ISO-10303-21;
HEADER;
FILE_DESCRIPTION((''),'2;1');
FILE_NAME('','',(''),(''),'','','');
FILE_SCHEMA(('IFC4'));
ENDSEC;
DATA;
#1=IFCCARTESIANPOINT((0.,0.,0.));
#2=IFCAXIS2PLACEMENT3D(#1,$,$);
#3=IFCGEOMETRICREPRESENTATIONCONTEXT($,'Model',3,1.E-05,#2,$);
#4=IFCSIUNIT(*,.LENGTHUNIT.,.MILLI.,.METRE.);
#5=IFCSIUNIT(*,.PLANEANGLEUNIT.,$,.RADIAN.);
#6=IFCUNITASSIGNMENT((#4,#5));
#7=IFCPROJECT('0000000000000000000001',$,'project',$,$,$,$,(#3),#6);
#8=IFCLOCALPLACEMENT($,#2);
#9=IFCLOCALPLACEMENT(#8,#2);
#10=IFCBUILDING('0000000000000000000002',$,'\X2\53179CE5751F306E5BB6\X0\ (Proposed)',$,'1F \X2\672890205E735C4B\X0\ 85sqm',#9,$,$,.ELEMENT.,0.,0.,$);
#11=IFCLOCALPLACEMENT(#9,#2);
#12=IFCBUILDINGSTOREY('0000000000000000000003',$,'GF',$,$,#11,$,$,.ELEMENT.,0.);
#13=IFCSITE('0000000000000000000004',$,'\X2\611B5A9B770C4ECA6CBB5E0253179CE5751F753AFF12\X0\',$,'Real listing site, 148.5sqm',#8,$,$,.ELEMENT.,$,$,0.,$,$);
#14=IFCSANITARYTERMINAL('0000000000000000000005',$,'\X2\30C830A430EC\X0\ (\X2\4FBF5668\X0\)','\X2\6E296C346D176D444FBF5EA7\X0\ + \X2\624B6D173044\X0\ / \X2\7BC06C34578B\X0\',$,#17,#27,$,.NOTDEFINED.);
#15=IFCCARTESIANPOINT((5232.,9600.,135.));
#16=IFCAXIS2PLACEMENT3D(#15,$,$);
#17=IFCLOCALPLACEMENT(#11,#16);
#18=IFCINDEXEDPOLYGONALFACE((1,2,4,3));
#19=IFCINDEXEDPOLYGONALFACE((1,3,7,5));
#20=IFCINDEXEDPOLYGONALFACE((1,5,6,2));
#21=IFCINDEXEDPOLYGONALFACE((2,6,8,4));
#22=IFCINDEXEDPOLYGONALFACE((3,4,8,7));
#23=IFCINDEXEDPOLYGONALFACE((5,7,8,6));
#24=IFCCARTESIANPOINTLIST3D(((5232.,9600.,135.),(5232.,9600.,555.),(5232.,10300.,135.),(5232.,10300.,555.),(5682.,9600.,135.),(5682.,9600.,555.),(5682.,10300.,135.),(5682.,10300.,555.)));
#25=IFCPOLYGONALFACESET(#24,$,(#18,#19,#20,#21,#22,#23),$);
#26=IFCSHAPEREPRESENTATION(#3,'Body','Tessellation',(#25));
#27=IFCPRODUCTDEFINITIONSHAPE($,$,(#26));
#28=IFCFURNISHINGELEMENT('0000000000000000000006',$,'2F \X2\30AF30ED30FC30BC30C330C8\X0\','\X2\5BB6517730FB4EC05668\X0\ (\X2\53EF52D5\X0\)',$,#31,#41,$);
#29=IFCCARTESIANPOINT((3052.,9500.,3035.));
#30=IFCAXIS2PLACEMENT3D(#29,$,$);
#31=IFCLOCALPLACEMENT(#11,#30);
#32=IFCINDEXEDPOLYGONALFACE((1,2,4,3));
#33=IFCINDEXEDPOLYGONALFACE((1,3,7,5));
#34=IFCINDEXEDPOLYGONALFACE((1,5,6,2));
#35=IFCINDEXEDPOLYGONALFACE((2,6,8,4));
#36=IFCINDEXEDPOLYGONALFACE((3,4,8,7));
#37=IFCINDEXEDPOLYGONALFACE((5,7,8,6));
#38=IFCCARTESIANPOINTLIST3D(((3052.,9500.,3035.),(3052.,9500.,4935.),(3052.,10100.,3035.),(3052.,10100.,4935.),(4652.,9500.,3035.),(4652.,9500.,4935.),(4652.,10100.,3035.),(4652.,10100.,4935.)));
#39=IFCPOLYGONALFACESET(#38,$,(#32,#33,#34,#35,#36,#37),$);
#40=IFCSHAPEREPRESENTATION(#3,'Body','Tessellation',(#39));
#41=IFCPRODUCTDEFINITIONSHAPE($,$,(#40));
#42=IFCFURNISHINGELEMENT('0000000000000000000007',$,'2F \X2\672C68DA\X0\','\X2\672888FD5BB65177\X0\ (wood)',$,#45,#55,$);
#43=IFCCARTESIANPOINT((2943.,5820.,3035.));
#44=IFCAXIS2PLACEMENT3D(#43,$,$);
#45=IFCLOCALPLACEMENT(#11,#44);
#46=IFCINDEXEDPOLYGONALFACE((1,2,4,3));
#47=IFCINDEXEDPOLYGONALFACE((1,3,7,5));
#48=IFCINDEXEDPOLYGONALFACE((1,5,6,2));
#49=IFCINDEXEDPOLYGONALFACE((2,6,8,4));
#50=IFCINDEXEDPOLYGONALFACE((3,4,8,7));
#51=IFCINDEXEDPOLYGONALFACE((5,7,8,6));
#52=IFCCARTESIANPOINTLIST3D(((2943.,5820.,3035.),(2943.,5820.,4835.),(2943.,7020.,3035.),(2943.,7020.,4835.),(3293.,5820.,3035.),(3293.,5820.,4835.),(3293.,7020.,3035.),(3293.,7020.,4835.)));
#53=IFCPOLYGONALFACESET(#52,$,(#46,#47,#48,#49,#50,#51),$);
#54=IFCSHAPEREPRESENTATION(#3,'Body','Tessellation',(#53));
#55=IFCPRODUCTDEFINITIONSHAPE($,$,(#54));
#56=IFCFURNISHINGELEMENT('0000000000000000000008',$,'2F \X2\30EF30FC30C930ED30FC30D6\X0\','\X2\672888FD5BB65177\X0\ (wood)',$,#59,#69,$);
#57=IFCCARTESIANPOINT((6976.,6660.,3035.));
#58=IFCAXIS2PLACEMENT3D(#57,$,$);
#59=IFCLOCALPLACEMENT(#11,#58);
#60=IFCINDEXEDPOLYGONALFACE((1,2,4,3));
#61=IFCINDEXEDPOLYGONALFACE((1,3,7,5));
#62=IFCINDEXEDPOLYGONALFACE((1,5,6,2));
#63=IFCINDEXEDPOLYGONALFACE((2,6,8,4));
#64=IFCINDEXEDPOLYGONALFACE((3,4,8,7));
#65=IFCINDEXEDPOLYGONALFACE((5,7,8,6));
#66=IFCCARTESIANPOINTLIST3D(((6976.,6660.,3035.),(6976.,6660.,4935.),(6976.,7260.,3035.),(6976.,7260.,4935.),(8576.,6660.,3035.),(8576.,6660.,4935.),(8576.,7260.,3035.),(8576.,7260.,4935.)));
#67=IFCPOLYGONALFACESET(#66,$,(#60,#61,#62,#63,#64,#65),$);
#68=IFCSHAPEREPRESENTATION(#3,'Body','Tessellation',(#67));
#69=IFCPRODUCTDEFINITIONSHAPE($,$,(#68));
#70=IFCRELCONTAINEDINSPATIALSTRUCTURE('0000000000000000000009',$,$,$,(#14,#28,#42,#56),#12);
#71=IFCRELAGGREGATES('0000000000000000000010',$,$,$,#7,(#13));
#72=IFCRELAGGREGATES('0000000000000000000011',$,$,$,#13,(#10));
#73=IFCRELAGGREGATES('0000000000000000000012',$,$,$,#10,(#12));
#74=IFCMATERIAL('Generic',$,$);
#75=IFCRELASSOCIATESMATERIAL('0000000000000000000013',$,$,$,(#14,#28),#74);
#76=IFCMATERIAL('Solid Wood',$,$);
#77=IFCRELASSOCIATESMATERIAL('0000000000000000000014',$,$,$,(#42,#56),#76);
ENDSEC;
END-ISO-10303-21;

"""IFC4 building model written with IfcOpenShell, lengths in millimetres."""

from ifc_helpers import new_model, si_unit, frame, frame_2d, origin, place, context, project, spatial, rectangle, extrude, material, element, save


model = new_model("IFC4")

# Units and contexts
model_context = context("Model", 3, precision=1e-05, world=origin())
ifc_project = project(units=[si_unit("LENGTHUNIT", "METRE", prefix="MILLI"), si_unit("PLANEANGLEUNIT", "RADIAN")], contexts=[model_context])

# Site, building, storey
site_placement = place(None, origin())
site = spatial("IfcSite", under=ifc_project, at=site_placement, Name="愛媛県今治市北鳥生町２", ObjectType="Real listing site, 148.5sqm", CompositionType="ELEMENT", RefElevation=0.0)
building_placement = place(site_placement, origin())
building = spatial("IfcBuilding", under=site, at=building_placement, Name="北鳥生の家 (Proposed)", ObjectType="1F 木造平屋 85sqm", CompositionType="ELEMENT", ElevationOfRefHeight=0.0, ElevationOfTerrain=0.0)
storey_placement = place(building_placement, origin())
storey = spatial("IfcBuildingStorey", under=building, at=storey_placement, Name="GF", CompositionType="ELEMENT", Elevation=0.0)

# Shared definitions
ifc_material_1 = material(Name="Solid Wood")

# Shared definitions
ifc_material_2 = material(Name="Generic")

# Sanitary terminal
sanitary_terminal_placement = place(storey_placement, frame((5232.0, 9600.0, 135.0)))
element("IfcSanitaryTerminal", 1, at=sanitary_terminal_placement, inside=storey, material=ifc_material_2, Name="トイレ (便器)", Description="温水洗浄便座 + 手洗い / 節水型", PredefinedType="NOTDEFINED", context=model_context, shape_type="SweptSolid", body=[
    extrude(rectangle(XDim=450.0, YDim=700.0, at=frame_2d((225.0, 350.0))), frame((5232.0, 9600.0, 135.0)), (0.0, 0.0, 1.0), 420.0),
])

# Furnishing elements
furnishing_1_placement = place(storey_placement, frame((3052.0, 9500.0, 3035.0)))
element("IfcFurnishingElement", 2, at=furnishing_1_placement, inside=storey, material=ifc_material_2, Name="2F クローゼット", Description="家具・什器 (可動)", context=model_context, shape_type="SweptSolid", body=[
    extrude(rectangle(XDim=1600.0, YDim=600.0, at=frame_2d((800.0, 300.0))), frame((3052.0, 9500.0, 3035.0)), (0.0, 0.0, 1.0), 1900.0),
])
furnishing_2_placement = place(storey_placement, frame((2943.0, 5820.0, 3035.0)))
element("IfcFurnishingElement", 3, at=furnishing_2_placement, inside=storey, material=ifc_material_1, Name="2F 本棚", Description="木製家具 (wood)", context=model_context, shape_type="SweptSolid", body=[
    extrude(rectangle(XDim=350.0, YDim=1200.0, at=frame_2d((175.0, 600.0))), frame((2943.0, 5820.0, 3035.0)), (0.0, 0.0, 1.0), 1800.0),
])
furnishing_3_placement = place(storey_placement, frame((6976.0, 6660.0, 3035.0)))
element("IfcFurnishingElement", 4, at=furnishing_3_placement, inside=storey, material=ifc_material_1, Name="2F ワードローブ", Description="木製家具 (wood)", context=model_context, shape_type="SweptSolid", body=[
    extrude(rectangle(XDim=1600.0, YDim=600.0, at=frame_2d((800.0, 300.0))), frame((6976.0, 6660.0, 3035.0)), (0.0, 0.0, 1.0), 1900.0),
])

save(model, "model.ifc")
